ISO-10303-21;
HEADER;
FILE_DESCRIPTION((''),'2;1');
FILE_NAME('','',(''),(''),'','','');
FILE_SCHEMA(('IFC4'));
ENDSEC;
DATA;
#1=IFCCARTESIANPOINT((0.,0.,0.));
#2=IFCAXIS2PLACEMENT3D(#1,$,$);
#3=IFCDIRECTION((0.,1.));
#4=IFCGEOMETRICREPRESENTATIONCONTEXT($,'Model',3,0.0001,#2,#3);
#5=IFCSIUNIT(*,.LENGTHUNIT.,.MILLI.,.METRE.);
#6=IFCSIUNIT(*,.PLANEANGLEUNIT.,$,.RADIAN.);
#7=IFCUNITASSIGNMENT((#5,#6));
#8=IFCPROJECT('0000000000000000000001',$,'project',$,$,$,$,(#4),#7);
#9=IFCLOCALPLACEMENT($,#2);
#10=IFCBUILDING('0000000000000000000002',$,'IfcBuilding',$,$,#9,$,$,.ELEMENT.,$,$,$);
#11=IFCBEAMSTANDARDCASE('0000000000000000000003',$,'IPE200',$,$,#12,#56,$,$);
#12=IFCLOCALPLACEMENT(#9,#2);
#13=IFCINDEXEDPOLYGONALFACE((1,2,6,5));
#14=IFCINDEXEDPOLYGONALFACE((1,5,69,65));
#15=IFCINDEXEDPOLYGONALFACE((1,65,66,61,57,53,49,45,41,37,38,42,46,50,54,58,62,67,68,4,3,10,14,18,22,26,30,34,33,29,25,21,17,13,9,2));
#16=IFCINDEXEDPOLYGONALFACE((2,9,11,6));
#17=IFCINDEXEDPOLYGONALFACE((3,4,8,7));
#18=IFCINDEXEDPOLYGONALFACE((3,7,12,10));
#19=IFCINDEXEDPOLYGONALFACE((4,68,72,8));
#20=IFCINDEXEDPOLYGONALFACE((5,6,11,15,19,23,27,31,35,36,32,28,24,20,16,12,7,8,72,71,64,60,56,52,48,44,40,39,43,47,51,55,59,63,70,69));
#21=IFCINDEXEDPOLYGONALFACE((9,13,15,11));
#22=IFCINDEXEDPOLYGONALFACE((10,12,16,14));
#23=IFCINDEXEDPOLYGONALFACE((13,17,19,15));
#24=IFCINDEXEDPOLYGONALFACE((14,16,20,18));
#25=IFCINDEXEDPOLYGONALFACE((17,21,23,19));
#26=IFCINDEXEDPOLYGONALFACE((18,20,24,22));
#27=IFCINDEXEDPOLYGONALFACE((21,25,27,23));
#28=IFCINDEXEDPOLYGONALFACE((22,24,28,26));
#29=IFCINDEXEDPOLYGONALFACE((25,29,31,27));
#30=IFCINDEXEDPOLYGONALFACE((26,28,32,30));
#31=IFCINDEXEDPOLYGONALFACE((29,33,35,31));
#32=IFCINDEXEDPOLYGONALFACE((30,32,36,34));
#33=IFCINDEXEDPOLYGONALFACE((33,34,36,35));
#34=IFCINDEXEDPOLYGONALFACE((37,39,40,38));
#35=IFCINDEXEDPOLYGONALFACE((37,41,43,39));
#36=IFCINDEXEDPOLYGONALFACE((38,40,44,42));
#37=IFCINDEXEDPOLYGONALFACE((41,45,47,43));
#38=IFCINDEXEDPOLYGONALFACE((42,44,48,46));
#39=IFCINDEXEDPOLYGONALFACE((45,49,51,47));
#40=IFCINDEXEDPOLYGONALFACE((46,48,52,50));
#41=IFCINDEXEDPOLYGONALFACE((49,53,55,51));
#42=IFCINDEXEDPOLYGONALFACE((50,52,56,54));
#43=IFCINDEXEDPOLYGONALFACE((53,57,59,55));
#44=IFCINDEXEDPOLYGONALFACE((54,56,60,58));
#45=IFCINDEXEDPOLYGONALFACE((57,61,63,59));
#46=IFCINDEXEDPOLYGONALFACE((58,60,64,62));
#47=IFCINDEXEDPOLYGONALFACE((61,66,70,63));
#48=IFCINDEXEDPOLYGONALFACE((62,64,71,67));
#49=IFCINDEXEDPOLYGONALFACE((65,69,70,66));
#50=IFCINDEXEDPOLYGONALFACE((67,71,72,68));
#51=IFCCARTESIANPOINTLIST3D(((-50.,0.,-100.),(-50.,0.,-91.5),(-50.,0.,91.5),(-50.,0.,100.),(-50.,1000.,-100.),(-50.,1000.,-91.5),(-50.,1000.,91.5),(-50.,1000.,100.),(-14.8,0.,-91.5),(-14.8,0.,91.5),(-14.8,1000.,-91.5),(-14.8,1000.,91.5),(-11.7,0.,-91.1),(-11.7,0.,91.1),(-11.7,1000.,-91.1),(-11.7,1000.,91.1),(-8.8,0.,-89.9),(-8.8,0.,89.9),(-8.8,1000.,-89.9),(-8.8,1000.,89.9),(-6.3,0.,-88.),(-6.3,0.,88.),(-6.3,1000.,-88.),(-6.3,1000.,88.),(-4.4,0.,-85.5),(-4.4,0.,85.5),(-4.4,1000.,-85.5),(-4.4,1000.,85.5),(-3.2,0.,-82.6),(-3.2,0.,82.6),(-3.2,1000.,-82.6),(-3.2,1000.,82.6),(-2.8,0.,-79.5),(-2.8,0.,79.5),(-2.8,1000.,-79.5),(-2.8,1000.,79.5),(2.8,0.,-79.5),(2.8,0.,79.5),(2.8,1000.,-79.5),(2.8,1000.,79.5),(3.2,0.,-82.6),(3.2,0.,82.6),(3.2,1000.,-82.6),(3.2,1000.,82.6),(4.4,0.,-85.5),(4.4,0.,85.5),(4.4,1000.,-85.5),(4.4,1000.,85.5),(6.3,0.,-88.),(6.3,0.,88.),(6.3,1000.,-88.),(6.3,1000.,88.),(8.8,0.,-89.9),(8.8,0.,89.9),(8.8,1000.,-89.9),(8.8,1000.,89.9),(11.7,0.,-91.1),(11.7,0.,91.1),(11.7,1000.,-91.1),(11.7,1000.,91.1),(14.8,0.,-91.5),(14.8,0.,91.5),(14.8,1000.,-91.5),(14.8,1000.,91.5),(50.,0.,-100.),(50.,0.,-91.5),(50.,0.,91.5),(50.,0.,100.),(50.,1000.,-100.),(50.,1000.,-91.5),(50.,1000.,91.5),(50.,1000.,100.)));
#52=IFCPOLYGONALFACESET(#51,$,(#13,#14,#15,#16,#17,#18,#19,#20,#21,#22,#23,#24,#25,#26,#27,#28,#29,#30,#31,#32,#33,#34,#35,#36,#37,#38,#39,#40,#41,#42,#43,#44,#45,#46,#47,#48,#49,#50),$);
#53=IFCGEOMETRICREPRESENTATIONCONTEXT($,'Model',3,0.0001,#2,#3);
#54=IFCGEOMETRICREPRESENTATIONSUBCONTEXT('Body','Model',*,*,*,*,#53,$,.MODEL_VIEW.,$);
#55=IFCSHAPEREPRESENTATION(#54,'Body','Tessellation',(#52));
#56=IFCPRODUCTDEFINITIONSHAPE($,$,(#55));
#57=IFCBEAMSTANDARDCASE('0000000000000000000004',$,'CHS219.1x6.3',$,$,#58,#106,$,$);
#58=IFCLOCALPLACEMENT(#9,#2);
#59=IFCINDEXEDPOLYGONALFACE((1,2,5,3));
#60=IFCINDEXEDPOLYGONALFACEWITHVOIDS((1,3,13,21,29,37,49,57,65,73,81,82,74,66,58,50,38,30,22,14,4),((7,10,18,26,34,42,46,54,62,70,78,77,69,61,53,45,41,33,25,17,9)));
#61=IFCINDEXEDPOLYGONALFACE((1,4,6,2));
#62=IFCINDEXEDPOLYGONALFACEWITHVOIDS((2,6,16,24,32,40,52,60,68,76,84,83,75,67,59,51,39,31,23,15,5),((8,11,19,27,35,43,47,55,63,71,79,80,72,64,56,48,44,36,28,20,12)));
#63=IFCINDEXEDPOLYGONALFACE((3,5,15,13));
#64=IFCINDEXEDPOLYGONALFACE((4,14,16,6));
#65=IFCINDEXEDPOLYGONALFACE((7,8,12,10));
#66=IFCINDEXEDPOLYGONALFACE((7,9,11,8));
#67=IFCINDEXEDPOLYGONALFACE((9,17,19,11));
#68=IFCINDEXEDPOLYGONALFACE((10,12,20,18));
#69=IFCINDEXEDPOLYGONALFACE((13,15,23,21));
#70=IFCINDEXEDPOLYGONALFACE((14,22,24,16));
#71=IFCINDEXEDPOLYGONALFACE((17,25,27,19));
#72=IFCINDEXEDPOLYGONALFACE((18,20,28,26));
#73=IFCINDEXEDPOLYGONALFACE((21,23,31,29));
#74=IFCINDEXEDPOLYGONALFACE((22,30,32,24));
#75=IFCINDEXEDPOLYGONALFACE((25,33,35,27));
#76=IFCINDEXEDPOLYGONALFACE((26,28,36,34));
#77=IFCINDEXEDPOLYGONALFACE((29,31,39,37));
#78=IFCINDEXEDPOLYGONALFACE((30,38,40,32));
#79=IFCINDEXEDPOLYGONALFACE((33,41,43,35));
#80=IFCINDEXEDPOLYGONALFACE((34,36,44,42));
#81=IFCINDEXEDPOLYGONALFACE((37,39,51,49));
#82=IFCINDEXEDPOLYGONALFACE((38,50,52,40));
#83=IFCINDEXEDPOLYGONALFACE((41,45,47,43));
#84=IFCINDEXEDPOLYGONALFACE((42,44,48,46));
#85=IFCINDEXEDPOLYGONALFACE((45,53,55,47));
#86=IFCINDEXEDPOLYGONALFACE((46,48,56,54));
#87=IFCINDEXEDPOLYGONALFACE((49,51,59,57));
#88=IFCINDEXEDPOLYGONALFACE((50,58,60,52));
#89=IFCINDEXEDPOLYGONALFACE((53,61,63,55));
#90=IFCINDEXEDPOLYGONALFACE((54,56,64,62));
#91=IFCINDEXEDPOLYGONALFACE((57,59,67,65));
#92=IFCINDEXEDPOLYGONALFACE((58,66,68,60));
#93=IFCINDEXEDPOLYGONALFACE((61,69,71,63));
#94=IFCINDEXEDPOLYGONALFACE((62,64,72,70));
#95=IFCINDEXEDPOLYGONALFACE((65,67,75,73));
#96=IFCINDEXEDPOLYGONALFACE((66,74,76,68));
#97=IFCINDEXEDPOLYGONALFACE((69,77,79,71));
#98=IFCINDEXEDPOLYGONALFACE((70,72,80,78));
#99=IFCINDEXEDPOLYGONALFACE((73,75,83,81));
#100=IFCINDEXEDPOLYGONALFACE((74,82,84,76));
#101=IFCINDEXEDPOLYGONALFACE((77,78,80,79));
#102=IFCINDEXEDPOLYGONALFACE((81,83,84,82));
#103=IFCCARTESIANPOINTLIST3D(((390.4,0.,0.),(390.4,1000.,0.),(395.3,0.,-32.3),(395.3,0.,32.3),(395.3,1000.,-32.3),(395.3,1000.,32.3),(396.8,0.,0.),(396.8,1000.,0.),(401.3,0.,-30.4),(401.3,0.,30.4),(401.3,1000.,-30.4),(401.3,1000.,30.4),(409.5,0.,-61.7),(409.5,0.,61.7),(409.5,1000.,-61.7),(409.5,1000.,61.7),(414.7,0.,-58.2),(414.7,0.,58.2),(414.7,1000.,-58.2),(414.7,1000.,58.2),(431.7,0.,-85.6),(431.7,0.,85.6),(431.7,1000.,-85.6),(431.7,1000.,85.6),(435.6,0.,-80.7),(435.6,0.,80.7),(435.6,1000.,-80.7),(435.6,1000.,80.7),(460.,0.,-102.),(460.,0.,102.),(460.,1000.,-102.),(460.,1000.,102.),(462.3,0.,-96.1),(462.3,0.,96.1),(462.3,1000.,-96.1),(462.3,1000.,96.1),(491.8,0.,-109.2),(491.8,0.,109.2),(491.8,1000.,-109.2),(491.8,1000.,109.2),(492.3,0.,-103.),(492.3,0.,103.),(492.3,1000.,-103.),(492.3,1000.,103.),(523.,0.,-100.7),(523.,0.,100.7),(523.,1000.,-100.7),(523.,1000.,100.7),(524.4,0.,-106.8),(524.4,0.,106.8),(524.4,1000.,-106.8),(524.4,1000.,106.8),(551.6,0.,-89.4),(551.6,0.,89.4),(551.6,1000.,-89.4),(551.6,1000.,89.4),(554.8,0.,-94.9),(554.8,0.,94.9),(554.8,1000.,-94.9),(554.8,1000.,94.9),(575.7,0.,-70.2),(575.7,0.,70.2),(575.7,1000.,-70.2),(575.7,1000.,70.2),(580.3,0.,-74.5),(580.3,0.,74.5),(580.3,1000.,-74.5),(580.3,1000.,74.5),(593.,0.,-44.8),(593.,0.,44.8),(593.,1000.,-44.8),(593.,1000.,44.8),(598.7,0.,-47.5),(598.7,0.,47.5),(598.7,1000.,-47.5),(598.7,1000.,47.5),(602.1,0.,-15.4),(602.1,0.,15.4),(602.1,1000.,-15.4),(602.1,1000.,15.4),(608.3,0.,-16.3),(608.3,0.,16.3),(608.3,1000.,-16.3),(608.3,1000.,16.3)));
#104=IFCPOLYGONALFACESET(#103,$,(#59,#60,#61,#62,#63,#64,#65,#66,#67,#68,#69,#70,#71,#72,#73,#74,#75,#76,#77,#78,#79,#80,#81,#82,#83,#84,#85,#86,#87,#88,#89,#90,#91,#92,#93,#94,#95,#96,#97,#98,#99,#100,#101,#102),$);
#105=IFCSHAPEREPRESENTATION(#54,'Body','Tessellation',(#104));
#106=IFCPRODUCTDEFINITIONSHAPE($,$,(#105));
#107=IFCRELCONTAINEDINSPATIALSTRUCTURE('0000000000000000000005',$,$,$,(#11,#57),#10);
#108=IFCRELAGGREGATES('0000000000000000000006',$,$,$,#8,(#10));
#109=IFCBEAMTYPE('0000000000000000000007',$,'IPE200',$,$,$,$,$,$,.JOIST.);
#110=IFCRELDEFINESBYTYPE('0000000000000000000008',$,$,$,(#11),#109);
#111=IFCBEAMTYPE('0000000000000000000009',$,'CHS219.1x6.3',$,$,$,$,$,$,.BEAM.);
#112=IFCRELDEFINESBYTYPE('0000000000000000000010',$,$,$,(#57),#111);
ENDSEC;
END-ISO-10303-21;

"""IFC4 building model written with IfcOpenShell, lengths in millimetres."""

from ifc_helpers import new_model, si_unit, direction, frame, origin, place, context, subcontext, project, spatial, hollow_circle, i_section, extrude, type_object, element, save


model = new_model("IFC4")

# Units and contexts
model_context_1 = context("Model", 3, precision=0.0001, world=origin(), true_north=direction((0.0, 1.0)))
model_context_2 = context("Model", 3, precision=0.0001, world=origin(), true_north=direction((0.0, 1.0)))
body_context = subcontext(model_context_1, "Body", "Model", "MODEL_VIEW")
ifc_project = project(units=[si_unit("LENGTHUNIT", "METRE", prefix="MILLI"), si_unit("PLANEANGLEUNIT", "RADIAN")], contexts=[model_context_2])

# Building
building_placement = place(None, origin())
building = spatial("IfcBuilding", under=ifc_project, at=building_placement, Name="IfcBuilding", CompositionType="ELEMENT")

# Beams
beam_type_1 = type_object("IfcBeamType", Name="IPE200", PredefinedType="JOIST")
beam_1_placement = place(None, frame((0.0, 0.0, 0.0), z_axis=(0.0, 1.0, 0.0), x_axis=(-1.0, 0.0, 0.0)))
element("IfcBeamStandardCase", 1, at=beam_1_placement, inside=building, type_object=beam_type_1, Name="IPE200", context=body_context, shape_type="SweptSolid", body=[
    extrude(i_section(OverallWidth=100.0, OverallDepth=200.0, WebThickness=5.6, FlangeThickness=8.5, FilletRadius=12.0), None, (0.0, 0.0, 1.0), 1000.0),
])
beam_type_2 = type_object("IfcBeamType", Name="CHS219.1x6.3", PredefinedType="BEAM")
beam_2_placement = place(None, frame((500.0, 0.0, 0.0), z_axis=(0.0, 1.0, 0.0), x_axis=(-1.0, 0.0, 0.0)))
element("IfcBeamStandardCase", 2, at=beam_2_placement, inside=building, type_object=beam_type_2, Name="CHS219.1x6.3", context=body_context, shape_type="SweptSolid", body=[
    extrude(hollow_circle(Radius=109.5, WallThickness=6.3), None, (0.0, 0.0, 1.0), 1000.0),
])

save(model, "model.ifc")
